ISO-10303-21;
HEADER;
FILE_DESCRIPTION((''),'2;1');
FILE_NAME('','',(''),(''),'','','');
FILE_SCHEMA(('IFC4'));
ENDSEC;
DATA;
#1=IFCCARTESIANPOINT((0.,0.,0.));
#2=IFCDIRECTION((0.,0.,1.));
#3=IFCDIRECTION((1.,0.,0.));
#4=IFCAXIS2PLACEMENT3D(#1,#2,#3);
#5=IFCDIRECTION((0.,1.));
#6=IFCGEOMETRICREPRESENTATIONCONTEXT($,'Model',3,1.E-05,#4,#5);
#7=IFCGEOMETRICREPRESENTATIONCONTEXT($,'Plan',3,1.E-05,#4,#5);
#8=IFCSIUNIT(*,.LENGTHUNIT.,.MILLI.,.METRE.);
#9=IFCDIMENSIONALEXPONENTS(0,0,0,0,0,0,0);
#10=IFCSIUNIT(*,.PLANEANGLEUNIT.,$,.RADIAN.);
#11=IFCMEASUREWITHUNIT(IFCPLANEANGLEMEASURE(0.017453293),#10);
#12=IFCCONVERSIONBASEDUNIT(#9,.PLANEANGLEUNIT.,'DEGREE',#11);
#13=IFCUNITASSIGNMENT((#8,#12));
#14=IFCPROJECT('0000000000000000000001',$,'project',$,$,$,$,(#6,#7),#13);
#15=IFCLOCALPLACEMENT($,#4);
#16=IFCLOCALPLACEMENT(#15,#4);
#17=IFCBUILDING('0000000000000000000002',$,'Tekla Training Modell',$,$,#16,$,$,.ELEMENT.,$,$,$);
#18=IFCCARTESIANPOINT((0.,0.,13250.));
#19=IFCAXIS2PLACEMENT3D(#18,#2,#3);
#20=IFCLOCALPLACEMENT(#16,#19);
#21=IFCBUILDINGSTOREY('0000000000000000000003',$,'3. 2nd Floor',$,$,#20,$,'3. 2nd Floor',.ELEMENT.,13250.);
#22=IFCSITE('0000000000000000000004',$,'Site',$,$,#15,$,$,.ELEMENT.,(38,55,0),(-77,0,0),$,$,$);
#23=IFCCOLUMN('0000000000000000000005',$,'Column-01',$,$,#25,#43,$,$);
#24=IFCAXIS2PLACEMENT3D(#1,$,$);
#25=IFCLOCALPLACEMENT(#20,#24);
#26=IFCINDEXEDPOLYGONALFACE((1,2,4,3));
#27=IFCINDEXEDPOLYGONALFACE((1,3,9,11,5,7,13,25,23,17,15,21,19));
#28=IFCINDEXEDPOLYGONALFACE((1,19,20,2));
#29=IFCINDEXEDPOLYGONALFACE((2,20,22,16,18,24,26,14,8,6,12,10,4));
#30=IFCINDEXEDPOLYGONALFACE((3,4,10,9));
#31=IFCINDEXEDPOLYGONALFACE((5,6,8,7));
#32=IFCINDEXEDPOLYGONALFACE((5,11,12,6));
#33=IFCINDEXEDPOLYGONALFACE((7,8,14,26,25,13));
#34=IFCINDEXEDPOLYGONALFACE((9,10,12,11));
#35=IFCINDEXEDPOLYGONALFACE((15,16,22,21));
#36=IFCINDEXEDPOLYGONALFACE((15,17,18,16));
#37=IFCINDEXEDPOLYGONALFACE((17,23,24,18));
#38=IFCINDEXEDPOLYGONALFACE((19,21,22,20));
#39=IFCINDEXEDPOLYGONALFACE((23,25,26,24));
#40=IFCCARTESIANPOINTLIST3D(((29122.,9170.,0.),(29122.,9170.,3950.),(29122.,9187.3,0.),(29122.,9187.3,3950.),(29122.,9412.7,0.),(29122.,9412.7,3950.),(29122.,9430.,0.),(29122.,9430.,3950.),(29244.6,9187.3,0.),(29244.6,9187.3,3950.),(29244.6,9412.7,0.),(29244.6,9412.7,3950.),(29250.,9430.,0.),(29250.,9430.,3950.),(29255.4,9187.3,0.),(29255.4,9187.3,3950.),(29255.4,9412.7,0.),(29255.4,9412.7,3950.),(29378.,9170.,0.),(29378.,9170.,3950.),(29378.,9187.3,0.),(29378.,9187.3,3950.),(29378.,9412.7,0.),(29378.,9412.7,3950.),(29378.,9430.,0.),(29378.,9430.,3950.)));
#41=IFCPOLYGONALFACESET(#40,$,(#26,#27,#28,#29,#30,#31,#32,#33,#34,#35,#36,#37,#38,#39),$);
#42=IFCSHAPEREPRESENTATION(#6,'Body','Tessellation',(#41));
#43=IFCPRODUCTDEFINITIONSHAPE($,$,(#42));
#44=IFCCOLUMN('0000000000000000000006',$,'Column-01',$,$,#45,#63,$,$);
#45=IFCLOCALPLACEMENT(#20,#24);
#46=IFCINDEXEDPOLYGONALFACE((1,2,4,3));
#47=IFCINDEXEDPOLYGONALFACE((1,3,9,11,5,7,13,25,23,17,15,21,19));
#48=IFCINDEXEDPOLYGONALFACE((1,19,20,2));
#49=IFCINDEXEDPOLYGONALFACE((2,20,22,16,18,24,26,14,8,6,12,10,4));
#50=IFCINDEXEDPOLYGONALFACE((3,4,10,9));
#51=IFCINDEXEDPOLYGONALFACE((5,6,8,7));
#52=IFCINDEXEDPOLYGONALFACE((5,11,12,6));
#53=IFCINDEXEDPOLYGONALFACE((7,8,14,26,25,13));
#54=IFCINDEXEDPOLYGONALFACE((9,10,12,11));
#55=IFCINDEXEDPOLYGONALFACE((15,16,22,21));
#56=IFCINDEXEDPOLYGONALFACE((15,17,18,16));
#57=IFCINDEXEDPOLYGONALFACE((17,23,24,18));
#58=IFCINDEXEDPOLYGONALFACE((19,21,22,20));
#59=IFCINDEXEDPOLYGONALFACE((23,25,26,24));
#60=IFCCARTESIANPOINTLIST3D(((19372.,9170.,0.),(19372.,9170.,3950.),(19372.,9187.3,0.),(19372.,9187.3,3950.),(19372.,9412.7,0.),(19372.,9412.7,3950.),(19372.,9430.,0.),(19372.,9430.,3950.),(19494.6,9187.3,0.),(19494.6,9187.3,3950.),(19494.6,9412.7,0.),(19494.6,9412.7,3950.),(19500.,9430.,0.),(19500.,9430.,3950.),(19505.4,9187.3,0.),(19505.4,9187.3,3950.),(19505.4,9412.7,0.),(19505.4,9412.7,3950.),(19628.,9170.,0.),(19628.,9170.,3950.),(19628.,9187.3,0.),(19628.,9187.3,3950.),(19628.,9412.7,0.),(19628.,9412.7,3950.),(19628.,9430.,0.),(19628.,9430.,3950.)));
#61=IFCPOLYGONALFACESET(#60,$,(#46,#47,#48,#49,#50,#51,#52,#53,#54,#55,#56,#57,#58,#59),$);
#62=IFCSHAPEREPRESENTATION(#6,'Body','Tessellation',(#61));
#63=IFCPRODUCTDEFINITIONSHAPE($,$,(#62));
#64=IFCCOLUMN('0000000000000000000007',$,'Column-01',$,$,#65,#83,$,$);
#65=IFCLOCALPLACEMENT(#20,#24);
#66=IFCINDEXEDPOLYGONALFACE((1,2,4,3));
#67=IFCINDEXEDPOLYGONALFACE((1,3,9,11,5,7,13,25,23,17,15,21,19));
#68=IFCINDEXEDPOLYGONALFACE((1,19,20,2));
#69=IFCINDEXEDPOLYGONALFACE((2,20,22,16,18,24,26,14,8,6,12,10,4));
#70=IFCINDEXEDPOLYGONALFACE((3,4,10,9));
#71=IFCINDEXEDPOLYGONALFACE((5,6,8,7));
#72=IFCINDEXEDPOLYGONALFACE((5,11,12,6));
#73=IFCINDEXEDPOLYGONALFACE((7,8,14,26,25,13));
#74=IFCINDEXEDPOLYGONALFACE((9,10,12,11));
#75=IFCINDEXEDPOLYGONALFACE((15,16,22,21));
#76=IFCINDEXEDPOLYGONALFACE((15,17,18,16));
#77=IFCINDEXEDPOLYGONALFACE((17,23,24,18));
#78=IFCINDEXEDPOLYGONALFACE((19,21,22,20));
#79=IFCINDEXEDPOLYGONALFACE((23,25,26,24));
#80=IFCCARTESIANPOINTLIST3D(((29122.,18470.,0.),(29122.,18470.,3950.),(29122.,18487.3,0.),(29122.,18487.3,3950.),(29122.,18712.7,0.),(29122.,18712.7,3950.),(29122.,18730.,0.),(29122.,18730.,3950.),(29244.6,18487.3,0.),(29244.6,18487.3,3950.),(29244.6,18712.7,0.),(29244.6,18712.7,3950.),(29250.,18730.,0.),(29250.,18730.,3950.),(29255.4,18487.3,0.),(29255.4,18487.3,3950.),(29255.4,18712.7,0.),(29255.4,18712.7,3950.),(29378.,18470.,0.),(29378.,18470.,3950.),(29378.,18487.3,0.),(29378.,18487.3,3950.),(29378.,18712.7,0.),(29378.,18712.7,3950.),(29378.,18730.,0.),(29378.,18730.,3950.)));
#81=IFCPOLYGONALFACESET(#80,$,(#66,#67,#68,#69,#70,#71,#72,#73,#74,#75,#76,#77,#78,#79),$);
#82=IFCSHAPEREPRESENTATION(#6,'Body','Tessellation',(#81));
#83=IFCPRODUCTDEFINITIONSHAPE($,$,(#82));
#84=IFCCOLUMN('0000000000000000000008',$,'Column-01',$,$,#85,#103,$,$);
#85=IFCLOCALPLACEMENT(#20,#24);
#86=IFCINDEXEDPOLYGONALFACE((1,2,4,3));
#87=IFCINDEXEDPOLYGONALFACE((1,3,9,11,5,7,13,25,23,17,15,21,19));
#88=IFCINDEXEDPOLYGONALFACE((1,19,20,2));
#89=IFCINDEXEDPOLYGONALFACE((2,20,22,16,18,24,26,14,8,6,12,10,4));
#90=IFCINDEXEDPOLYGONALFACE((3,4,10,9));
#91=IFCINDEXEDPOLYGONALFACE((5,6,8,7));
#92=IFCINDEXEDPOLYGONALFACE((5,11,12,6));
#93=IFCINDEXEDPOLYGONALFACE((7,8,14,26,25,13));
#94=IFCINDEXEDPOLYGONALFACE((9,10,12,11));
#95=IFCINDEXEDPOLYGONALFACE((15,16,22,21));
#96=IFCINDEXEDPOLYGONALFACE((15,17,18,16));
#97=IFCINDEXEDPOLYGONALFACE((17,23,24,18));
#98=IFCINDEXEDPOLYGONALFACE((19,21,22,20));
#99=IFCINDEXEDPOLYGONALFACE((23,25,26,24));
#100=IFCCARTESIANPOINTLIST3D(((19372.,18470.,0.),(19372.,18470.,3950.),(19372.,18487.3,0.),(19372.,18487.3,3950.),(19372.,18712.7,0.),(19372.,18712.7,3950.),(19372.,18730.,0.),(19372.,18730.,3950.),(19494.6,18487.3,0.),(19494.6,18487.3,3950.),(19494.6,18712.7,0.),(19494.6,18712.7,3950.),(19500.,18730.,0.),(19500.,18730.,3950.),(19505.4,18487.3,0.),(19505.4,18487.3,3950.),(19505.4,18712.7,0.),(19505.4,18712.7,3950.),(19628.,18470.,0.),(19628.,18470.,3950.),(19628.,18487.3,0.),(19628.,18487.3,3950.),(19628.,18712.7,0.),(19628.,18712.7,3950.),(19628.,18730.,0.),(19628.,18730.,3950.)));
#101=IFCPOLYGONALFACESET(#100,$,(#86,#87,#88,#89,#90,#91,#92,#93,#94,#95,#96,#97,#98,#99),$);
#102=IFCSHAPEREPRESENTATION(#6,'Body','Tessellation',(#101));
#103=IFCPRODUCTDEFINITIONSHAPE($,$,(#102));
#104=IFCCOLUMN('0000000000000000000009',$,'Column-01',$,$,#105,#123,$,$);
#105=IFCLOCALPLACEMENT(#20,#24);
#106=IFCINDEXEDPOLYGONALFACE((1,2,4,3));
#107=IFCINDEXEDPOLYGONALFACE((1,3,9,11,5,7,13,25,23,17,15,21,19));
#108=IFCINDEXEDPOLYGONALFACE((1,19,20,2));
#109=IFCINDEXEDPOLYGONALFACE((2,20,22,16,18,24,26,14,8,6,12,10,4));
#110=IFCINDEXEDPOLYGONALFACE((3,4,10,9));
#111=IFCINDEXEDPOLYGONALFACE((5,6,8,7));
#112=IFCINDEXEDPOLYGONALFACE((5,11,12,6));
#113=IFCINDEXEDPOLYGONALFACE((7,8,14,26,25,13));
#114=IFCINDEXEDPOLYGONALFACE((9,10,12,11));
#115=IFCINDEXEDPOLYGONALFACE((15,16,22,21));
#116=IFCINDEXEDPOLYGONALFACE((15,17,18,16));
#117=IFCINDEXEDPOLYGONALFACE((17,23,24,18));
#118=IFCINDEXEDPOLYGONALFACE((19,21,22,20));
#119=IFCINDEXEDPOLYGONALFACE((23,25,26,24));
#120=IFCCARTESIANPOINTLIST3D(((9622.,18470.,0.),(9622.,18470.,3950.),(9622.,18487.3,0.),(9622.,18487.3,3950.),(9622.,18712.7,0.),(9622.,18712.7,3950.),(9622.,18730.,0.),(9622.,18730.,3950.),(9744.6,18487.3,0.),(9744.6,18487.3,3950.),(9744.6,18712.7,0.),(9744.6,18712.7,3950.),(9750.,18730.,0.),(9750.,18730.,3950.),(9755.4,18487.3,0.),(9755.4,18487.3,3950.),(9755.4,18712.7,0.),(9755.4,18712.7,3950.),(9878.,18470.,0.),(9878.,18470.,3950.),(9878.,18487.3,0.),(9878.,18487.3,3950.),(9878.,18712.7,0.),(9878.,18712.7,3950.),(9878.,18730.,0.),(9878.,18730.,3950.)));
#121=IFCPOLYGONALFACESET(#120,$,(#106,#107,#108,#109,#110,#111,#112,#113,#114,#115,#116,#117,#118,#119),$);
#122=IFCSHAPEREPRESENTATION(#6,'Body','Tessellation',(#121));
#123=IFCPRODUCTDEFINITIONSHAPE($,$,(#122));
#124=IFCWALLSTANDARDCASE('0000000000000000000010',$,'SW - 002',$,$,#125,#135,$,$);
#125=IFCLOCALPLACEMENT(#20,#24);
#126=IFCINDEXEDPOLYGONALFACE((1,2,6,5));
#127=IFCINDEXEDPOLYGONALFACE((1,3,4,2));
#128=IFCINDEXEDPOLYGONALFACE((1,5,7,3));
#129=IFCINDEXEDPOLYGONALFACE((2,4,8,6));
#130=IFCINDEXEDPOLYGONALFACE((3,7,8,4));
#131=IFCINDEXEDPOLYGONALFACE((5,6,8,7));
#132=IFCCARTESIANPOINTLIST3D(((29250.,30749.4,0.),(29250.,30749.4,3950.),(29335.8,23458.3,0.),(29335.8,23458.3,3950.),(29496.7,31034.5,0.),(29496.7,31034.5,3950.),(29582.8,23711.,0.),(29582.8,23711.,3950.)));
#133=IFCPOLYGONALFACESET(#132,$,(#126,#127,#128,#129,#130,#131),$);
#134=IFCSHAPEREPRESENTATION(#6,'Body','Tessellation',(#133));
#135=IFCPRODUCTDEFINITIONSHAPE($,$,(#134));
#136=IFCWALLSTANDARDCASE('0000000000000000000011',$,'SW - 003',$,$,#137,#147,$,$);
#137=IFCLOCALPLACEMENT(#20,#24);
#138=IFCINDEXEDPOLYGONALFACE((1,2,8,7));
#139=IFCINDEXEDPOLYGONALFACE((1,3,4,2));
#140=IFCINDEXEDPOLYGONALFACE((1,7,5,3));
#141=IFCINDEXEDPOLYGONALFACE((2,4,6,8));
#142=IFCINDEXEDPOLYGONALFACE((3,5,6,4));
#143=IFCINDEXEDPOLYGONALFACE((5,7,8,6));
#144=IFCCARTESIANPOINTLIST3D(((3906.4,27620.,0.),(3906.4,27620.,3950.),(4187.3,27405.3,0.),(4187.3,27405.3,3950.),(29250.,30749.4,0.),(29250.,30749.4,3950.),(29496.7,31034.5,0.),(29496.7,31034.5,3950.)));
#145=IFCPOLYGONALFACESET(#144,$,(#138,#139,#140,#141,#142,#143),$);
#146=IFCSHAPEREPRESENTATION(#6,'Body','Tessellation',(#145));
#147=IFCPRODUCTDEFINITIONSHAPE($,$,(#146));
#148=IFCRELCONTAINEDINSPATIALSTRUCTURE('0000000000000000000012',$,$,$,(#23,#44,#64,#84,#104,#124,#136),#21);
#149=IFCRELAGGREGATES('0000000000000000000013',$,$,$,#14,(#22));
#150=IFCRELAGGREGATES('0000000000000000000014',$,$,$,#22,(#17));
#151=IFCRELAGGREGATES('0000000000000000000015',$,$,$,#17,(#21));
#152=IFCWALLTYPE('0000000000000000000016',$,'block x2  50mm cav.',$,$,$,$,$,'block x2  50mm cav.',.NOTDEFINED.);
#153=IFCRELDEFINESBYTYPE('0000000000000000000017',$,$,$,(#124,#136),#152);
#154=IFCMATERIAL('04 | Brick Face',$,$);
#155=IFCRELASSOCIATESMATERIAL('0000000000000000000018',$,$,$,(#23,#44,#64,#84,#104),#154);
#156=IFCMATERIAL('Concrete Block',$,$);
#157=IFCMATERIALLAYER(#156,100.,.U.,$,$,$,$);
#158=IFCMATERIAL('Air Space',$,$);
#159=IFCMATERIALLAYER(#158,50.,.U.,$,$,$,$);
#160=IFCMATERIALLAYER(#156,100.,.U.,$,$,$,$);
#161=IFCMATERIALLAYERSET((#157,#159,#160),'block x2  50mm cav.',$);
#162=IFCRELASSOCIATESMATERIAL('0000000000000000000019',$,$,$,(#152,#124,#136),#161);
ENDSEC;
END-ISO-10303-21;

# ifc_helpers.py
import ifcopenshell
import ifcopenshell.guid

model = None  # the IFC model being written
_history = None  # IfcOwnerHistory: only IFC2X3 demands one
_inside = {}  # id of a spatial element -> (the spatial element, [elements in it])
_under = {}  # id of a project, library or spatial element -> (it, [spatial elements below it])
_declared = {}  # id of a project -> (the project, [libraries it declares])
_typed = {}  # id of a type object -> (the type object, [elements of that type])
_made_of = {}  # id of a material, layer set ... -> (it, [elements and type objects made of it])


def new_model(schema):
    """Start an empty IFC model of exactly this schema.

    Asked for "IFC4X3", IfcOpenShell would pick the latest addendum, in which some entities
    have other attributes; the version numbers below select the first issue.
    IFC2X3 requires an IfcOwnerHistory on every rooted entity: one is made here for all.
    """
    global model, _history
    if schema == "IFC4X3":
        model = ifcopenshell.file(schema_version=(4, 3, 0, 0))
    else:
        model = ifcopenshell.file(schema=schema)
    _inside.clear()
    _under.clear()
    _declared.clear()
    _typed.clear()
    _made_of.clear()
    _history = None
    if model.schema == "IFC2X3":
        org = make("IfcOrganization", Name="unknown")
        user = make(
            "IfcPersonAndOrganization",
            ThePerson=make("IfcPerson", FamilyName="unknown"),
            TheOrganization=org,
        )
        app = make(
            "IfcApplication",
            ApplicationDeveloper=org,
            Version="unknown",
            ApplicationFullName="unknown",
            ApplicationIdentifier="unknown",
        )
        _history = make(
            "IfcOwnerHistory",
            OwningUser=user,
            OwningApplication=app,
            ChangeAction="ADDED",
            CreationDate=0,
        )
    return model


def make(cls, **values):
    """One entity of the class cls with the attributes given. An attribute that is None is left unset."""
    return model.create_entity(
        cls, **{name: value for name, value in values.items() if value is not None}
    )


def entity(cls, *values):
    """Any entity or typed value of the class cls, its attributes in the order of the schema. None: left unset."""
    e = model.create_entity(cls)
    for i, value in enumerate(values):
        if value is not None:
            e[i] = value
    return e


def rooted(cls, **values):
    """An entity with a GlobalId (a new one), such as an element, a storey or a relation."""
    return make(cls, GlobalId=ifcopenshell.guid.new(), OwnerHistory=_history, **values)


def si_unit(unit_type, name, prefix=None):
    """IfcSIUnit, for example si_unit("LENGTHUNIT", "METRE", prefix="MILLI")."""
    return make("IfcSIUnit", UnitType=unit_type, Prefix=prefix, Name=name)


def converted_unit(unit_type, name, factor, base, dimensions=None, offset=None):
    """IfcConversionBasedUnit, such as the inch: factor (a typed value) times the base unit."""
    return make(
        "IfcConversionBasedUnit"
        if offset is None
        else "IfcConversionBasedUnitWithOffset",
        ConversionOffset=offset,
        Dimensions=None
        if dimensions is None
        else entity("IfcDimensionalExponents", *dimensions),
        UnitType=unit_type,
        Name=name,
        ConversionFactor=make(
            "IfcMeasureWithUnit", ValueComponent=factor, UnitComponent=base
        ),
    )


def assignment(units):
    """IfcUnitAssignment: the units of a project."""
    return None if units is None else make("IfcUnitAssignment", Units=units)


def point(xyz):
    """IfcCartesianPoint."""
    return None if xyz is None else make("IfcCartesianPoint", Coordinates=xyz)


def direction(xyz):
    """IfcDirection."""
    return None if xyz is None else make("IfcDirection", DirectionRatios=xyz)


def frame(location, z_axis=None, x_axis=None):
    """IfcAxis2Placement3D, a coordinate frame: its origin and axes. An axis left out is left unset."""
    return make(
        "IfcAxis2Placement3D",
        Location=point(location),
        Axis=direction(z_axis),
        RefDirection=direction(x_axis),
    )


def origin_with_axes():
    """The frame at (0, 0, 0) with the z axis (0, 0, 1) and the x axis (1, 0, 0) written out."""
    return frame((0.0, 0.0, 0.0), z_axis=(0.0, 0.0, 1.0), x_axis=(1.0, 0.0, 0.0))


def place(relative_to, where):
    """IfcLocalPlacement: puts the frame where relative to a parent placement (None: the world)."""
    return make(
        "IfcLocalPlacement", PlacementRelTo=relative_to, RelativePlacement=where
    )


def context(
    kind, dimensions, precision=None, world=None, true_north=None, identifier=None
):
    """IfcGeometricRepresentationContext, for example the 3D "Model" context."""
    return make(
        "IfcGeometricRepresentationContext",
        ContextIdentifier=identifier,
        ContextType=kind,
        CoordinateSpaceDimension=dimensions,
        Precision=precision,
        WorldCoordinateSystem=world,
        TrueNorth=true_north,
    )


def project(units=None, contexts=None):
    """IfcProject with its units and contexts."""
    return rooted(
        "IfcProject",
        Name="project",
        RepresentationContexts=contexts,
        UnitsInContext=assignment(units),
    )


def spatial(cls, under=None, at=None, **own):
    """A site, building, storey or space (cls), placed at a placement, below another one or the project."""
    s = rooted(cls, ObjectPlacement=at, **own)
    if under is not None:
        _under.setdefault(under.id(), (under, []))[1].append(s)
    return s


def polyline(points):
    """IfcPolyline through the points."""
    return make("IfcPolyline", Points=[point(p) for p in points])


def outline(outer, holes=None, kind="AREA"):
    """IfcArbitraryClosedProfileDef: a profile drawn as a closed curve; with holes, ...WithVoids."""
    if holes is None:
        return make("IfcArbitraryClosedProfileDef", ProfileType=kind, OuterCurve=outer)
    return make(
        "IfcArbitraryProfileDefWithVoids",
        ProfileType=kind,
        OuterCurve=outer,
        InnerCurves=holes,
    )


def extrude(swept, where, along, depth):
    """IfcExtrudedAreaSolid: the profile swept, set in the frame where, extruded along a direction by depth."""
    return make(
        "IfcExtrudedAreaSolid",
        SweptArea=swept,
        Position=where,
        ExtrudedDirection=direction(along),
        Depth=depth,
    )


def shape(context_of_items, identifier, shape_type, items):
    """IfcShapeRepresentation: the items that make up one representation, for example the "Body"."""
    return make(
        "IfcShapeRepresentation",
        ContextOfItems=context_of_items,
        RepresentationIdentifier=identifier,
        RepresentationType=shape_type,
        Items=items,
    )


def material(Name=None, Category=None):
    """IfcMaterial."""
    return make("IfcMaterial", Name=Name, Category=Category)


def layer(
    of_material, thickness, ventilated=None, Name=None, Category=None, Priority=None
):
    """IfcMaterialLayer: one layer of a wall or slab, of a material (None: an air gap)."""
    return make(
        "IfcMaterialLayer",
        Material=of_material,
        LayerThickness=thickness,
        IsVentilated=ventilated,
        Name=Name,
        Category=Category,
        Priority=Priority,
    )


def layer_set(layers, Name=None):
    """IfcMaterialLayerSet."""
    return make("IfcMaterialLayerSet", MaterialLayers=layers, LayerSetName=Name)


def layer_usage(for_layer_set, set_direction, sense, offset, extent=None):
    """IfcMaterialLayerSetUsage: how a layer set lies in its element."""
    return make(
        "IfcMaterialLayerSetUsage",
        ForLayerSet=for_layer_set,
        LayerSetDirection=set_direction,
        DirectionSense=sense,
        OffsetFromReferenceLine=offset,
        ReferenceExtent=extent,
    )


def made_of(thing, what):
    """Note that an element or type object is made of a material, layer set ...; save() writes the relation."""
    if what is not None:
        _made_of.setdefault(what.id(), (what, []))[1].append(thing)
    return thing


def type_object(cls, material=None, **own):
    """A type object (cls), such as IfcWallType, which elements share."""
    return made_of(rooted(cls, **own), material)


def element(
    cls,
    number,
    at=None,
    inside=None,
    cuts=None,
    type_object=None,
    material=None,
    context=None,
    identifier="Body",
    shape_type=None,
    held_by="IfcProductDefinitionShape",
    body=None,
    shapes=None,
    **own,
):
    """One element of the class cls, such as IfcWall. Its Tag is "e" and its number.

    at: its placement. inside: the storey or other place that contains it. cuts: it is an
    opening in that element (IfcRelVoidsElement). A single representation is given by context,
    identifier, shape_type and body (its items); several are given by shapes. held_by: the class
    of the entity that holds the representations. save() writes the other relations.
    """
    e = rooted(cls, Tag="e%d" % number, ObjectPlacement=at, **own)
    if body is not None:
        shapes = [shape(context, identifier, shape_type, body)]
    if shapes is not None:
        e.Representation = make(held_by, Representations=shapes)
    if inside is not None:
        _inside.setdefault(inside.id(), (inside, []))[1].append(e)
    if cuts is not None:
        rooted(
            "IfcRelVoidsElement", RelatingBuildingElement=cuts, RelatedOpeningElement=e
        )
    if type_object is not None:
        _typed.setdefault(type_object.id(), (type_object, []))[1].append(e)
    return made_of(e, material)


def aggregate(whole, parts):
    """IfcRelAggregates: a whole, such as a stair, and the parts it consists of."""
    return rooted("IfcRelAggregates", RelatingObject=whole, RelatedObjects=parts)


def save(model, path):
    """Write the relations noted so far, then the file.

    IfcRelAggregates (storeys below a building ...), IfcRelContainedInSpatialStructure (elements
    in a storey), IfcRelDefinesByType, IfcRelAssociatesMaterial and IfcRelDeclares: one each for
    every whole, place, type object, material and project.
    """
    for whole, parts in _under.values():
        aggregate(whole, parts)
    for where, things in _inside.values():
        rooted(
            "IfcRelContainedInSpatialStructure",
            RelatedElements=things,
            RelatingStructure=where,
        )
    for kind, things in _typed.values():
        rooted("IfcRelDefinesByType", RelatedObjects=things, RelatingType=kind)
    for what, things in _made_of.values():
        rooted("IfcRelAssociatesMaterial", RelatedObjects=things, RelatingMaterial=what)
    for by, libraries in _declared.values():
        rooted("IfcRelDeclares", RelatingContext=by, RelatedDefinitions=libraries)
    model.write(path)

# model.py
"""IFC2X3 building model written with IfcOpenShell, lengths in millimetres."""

from ifc_helpers import new_model, entity, si_unit, converted_unit, direction, frame, origin_with_axes, place, context, project, spatial, polyline, outline, extrude, material, layer, layer_set, layer_usage, type_object, element, save


model = new_model("IFC2X3")

# Units and contexts
model_context = context("Model", 3, precision=1e-05, world=origin_with_axes(), true_north=direction((0.0, 1.0)))
plan_context = context("Plan", 3, precision=1e-05, world=origin_with_axes(), true_north=direction((0.0, 1.0)))
ifc_project = project(units=[si_unit("LENGTHUNIT", "METRE", prefix="MILLI"), converted_unit("PLANEANGLEUNIT", "DEGREE", entity("IfcPlaneAngleMeasure", 0.017453293), si_unit("PLANEANGLEUNIT", "RADIAN"), dimensions=[0, 0, 0, 0, 0, 0, 0])], contexts=[model_context, plan_context])

# Site, building, storey
site_placement = place(None, origin_with_axes())
site = spatial("IfcSite", under=ifc_project, at=site_placement, Name="Site", CompositionType="ELEMENT", RefLatitude=(38, 55, 0), RefLongitude=(-77, 0, 0))
building_placement = place(site_placement, origin_with_axes())
building = spatial("IfcBuilding", under=site, at=building_placement, Name="Tekla Training Modell", CompositionType="ELEMENT")
storey_placement = place(building_placement, frame((0.0, 0.0, 13250.0), z_axis=(0.0, 0.0, 1.0), x_axis=(1.0, 0.0, 0.0)))
storey = spatial("IfcBuildingStorey", under=building, at=storey_placement, Name="3. 2nd Floor", LongName="3. 2nd Floor", CompositionType="ELEMENT", Elevation=13250.0)

# Columns
ifc_material_1 = material(Name="04 | Brick Face")
for number, where, z_axis, x_axis, name in (
    (1, (29250.0, 9300.0, 0.0), (0.0, 0.0, 1.0), (1.0, 0.0, 0.0), "Column-01"),
    (2, (19500.0, 9300.0, 0.0), (0.0, 0.0, 1.0), (1.0, 0.0, 0.0), "Column-01"),
    (3, (29250.0, 18600.0, 0.0), (0.0, 0.0, 1.0), (1.0, 0.0, 0.0), "Column-01"),
    (4, (19500.0, 18600.0, 0.0), (0.0, 0.0, 1.0), (1.0, 0.0, 0.0), "Column-01"),
    (5, (9750.0, 18600.0, 0.0), (0.0, 0.0, 1.0), (1.0, 0.0, 0.0), "Column-01"),
):
    element("IfcColumn", number, at=place(storey_placement, frame(where, z_axis=z_axis, x_axis=x_axis)), inside=storey, material=ifc_material_1, Name=name, context=model_context, shape_type="SweptSolid", body=[
        extrude(outline(polyline([(0.0, 130.0), (-128.0, 130.0), (-128.0, 112.7), (-5.3, 112.7), (-5.3, -112.7), (-128.0, -112.7), (-128.0, -130.0), (128.0, -130.0), (128.0, -112.7), (5.3, -112.7), (5.3, 112.7), (128.0, 112.7), (128.0, 130.0), (0.0, 130.0)])), origin_with_axes(), (0.0, 0.0, 1.0), 3950.0),
    ])

# Walls
ifc_material_2 = material(Name="Concrete Block")
ifc_layer_1 = layer(ifc_material_2, 100.0, ventilated="UNKNOWN")
ifc_material_3 = material(Name="Air Space")
ifc_layer_2 = layer(ifc_material_3, 50.0, ventilated="UNKNOWN")
ifc_layer_3 = layer(ifc_material_2, 100.0, ventilated="UNKNOWN")
ifc_layer_set = layer_set([ifc_layer_1, ifc_layer_2, ifc_layer_3], Name="block x2  50mm cav.")
ifc_layer_usage_1 = layer_usage(ifc_layer_set, "AXIS2", "NEGATIVE", 0.0)
wall_type = type_object("IfcWallType", Name="block x2  50mm cav.", ElementType="block x2  50mm cav.", PredefinedType="NOTDEFINED", material=ifc_layer_set)
wall_1_placement = place(storey_placement, frame((29335.8, 23458.3, 0.0), z_axis=(0.0, 0.0, 1.0), x_axis=(-0.01176, 0.999931, 0.0)))
element("IfcWallStandardCase", 6, at=wall_1_placement, inside=storey, type_object=wall_type, material=ifc_layer_usage_1, Name="SW - 002", context=model_context, shape_type="SweptSolid", body=[
    extrude(outline(polyline([(249.7, -250.0), (7573.7, -250.0), (7291.5, 0.0), (0.0, 0.0), (249.7, -250.0)])), origin_with_axes(), (0.0, 0.0, 1.0), 3950.0),
])
ifc_layer_usage_2 = layer_usage(ifc_layer_set, "AXIS2", "NEGATIVE", 0.0)
wall_2_placement = place(storey_placement, frame((29250.0, 30749.4, 0.0), z_axis=(0.0, 0.0, 1.0), x_axis=(-0.991216, -0.132256, 0.0)))
element("IfcWallStandardCase", 7, at=wall_2_placement, inside=storey, type_object=wall_type, material=ifc_layer_usage_2, Name="SW - 003", context=model_context, shape_type="SweptSolid", body=[
    extrude(outline(polyline([(-282.2, -250.0), (25534.8, -250.0), (25284.8, 0.0), (0.0, 0.0), (-282.2, -250.0)])), origin_with_axes(), (0.0, 0.0, 1.0), 3950.0),
])

save(model, "model.ifc")
